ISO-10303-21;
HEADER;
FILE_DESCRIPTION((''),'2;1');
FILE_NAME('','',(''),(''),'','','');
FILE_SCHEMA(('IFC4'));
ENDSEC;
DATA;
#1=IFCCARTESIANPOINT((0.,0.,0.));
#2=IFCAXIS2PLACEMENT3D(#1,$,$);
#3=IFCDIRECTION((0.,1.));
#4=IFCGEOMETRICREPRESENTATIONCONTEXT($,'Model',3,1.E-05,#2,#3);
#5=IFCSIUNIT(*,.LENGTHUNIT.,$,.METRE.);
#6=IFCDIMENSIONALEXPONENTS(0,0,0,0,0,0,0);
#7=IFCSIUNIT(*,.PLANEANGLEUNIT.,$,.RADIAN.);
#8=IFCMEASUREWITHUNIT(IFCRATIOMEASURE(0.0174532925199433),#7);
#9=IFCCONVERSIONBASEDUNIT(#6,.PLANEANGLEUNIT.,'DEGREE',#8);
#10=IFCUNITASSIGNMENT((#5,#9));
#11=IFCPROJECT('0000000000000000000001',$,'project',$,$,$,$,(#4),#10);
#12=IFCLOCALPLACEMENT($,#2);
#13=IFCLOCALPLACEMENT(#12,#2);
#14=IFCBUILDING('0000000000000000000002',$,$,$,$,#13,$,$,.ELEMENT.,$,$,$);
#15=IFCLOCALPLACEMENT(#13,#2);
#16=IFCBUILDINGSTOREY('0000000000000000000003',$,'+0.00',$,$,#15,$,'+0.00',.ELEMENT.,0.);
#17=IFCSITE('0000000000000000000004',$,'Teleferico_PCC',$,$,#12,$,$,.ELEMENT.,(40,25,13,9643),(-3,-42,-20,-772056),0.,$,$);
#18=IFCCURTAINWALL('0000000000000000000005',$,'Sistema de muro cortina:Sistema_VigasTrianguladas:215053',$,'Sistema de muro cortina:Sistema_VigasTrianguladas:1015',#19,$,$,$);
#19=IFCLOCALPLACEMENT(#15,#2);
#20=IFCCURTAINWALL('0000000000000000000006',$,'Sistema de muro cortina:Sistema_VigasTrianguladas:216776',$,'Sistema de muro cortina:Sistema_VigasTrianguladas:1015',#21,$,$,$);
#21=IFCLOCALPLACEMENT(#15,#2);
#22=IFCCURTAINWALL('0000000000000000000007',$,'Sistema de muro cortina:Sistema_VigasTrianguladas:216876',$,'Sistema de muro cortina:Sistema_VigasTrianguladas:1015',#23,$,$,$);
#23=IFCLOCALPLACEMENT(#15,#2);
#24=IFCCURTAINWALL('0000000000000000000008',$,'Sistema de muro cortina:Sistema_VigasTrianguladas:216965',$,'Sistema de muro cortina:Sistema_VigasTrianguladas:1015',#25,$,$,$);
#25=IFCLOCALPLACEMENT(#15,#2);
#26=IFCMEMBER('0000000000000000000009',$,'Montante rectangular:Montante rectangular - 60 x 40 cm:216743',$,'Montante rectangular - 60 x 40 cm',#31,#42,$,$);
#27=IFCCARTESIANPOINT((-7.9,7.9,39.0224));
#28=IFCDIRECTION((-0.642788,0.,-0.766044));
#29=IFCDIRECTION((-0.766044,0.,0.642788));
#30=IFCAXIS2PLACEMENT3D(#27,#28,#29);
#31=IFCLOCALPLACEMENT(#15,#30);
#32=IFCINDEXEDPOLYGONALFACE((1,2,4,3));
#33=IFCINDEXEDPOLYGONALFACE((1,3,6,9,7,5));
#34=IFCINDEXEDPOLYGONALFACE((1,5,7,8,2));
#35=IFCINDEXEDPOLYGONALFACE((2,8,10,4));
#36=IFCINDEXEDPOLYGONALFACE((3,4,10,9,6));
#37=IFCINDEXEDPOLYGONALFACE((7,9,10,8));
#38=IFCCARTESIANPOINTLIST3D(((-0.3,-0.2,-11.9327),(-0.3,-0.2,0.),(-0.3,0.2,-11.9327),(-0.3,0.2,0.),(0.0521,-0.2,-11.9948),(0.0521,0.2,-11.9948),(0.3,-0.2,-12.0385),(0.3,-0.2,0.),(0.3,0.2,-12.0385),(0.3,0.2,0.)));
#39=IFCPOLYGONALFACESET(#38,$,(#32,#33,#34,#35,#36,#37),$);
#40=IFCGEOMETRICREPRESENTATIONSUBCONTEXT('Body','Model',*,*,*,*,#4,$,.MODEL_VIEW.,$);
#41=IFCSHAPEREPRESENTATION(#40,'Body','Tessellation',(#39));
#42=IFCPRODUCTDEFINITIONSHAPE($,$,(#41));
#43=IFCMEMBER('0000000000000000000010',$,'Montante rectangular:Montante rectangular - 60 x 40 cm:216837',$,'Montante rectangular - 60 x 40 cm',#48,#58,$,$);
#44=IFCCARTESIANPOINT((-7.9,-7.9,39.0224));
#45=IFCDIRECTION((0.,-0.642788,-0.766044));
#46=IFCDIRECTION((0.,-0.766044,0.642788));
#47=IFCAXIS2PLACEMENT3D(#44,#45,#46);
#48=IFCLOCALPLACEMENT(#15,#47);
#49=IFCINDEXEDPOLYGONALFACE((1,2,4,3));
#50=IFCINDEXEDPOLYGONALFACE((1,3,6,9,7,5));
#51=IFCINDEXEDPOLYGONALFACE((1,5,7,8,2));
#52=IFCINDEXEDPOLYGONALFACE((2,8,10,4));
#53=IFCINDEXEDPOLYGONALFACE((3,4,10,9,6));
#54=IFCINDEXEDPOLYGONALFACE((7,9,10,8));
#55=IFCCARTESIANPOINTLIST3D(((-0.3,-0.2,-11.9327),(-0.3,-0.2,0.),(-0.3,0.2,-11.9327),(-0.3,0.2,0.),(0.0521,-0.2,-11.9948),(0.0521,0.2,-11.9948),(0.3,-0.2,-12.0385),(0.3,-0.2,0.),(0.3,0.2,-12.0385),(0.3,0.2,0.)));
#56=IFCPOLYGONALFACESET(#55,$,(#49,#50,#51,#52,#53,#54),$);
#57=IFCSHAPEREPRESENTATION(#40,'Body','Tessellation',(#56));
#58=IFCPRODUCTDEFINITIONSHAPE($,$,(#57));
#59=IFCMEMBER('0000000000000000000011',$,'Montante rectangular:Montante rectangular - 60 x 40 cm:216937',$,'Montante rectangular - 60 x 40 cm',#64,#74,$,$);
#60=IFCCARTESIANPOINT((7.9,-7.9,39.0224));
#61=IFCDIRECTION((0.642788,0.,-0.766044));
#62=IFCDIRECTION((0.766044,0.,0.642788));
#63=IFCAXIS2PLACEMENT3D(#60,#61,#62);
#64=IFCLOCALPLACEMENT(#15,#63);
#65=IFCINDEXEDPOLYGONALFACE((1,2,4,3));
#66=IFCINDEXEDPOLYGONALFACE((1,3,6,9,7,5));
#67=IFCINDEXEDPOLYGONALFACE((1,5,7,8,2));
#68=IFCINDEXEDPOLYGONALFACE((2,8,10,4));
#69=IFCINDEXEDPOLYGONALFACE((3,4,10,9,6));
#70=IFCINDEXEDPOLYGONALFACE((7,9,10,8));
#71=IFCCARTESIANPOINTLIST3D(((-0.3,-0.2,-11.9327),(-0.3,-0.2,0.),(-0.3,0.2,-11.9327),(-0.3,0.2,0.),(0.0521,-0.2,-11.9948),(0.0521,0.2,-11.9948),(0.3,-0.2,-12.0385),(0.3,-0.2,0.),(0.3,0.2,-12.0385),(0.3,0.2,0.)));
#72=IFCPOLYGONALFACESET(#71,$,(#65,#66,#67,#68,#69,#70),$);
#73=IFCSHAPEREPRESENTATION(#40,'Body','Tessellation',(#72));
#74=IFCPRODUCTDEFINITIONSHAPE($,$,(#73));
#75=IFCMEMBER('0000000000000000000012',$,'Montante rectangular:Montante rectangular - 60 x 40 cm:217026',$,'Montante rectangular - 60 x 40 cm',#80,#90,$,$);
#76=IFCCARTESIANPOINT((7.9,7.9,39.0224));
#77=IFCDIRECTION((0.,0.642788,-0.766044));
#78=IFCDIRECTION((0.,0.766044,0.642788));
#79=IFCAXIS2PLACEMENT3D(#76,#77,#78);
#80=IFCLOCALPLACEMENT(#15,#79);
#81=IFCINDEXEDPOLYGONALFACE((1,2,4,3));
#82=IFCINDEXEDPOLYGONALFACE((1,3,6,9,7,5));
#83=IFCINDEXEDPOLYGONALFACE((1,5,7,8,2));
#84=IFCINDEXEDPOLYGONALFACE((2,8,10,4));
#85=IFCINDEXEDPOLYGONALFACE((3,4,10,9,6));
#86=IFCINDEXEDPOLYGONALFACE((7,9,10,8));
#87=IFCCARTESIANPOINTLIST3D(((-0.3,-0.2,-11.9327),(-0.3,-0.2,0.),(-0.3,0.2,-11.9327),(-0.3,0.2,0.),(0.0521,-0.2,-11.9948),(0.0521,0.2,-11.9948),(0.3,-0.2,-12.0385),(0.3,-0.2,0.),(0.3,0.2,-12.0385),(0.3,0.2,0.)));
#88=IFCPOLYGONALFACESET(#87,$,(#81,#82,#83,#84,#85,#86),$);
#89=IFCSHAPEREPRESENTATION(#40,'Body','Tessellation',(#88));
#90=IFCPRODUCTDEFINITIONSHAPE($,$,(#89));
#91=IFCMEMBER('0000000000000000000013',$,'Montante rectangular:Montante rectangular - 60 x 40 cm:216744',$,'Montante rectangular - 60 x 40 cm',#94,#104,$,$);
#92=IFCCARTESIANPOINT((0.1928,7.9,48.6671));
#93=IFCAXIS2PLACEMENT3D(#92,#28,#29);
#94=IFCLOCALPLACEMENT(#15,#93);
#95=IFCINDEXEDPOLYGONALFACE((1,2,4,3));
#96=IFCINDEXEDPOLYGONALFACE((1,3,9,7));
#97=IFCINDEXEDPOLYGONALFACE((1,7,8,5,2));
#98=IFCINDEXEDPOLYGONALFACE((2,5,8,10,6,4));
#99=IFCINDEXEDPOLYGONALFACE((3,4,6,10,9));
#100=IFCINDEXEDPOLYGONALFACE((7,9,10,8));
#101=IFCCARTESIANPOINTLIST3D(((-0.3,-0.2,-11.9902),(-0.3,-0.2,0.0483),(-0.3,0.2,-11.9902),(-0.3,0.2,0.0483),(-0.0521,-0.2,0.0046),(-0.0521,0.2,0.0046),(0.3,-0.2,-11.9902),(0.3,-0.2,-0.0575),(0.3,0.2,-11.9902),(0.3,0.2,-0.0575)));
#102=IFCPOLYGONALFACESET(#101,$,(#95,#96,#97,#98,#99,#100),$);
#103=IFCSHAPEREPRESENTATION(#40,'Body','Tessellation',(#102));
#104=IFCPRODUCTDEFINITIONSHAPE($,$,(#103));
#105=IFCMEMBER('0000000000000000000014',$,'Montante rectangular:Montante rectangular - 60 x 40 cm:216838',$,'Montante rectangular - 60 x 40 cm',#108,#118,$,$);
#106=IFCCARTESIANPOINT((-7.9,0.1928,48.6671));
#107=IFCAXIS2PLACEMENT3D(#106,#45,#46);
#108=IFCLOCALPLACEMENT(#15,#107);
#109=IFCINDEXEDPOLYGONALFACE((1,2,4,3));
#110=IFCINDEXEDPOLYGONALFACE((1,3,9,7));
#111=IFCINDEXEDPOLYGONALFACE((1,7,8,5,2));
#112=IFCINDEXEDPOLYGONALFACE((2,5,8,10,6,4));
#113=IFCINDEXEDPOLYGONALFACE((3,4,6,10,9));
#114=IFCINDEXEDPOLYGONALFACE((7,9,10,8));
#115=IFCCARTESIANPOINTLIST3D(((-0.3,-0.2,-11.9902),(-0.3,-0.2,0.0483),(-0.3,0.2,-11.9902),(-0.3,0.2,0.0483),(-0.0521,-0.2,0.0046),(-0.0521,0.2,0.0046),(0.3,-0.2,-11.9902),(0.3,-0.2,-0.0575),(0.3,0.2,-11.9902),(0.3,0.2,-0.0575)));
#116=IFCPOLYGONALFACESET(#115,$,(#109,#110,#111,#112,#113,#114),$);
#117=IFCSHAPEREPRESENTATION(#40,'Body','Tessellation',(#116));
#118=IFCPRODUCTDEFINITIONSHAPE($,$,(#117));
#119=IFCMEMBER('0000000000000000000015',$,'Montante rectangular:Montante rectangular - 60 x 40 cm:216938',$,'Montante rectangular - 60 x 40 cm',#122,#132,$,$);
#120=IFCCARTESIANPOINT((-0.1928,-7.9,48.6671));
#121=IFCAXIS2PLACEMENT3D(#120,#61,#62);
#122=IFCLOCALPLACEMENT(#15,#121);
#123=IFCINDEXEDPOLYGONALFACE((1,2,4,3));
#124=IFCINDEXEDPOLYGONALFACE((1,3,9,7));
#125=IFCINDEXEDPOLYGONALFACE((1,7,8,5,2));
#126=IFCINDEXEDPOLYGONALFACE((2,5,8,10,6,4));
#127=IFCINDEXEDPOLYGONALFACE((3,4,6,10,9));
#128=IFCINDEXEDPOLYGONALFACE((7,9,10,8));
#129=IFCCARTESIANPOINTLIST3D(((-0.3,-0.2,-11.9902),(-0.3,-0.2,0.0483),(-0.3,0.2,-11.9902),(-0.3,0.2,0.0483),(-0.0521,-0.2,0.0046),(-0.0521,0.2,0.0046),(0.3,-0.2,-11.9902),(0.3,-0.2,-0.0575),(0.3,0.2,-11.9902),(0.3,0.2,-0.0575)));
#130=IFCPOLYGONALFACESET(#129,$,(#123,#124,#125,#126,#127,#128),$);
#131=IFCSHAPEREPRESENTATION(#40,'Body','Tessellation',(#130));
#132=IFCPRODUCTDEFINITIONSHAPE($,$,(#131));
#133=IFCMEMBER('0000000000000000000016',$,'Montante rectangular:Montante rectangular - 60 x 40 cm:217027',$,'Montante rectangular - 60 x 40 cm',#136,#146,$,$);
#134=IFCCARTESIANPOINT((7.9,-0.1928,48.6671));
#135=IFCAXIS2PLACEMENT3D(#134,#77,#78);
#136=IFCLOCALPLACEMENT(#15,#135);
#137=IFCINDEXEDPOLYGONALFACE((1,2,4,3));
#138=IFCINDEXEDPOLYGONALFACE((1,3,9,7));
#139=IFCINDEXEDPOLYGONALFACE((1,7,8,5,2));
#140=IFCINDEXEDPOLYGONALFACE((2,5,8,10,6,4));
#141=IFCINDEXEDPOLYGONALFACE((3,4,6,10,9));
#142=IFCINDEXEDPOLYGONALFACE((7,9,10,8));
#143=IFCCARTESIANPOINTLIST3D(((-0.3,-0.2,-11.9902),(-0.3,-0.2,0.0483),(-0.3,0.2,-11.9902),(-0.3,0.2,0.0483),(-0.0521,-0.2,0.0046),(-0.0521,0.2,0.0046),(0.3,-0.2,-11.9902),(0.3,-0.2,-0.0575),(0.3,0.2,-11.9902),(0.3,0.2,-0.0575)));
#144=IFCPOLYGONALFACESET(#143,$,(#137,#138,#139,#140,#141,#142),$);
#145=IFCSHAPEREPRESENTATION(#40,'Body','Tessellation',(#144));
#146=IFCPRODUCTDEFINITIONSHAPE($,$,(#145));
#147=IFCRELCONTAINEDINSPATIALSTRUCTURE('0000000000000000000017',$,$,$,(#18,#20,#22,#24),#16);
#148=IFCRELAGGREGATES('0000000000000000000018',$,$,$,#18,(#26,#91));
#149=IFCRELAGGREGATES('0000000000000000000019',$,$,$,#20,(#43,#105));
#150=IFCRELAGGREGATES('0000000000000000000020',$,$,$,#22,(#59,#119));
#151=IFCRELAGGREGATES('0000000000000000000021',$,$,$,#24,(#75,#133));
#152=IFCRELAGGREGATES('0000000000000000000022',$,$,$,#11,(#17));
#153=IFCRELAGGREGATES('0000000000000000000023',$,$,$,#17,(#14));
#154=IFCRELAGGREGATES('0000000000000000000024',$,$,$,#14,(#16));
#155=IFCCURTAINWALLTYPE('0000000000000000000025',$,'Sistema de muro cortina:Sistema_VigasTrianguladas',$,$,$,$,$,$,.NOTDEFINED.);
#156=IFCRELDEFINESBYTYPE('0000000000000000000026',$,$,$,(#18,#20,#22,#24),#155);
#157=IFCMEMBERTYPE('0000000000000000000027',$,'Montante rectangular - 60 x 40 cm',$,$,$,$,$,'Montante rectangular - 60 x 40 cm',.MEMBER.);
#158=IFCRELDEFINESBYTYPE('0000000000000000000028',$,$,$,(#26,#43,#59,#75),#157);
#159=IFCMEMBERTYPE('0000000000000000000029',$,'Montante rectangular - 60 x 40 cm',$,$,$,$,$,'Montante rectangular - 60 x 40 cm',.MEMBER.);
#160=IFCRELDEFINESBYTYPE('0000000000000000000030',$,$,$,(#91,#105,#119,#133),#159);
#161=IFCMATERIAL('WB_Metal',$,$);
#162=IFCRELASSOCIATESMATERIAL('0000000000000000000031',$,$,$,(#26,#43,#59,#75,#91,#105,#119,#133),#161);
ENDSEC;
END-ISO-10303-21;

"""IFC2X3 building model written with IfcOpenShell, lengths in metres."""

from ifc_helpers import new_model, entity, si_unit, converted_unit, direction, frame, origin, origin_2d_with_axis, place, context, subcontext, project, spatial, polyline, rectangle, extrude, clip, bounded_halfspace, source, transform, mapped, material, type_object, type_shapes, element, aggregate, save


model = new_model("IFC2X3")

# Units and contexts
model_context = context("Model", 3, precision=1e-05, world=origin(), true_north=direction((0.0, 1.0)))
body_context = subcontext(model_context, "Body", "Model", "MODEL_VIEW")
ifc_project = project(units=[si_unit("LENGTHUNIT", "METRE"), converted_unit("PLANEANGLEUNIT", "DEGREE", entity("IfcRatioMeasure", 0.0174532925199433), si_unit("PLANEANGLEUNIT", "RADIAN"), dimensions=[0, 0, 0, 0, 0, 0, 0])], contexts=[model_context])

# Site, building, storey
site_placement = place(None, origin())
site = spatial("IfcSite", under=ifc_project, at=site_placement, Name="Teleferico_PCC", CompositionType="ELEMENT", RefLatitude=(40, 25, 13, 9643), RefLongitude=(-3, -42, -20, -772056), RefElevation=0.0)
building_placement = place(site_placement, origin())
building = spatial("IfcBuilding", under=site, at=building_placement, CompositionType="ELEMENT")
storey_placement = place(building_placement, origin())
storey = spatial("IfcBuildingStorey", under=building, at=storey_placement, Name="+0.00", LongName="+0.00", CompositionType="ELEMENT", Elevation=0.0)

# Curtain walls
curtain_wall_type = type_object("IfcCurtainWallType", Name="Sistema de muro cortina:Sistema_VigasTrianguladas", PredefinedType="NOTDEFINED")
curtain_wall_1_placement = place(storey_placement, origin())
curtain_wall_1 = element("IfcCurtainWall", 1, at=curtain_wall_1_placement, inside=storey, type_object=curtain_wall_type, Name="Sistema de muro cortina:Sistema_VigasTrianguladas:215053", ObjectType="Sistema de muro cortina:Sistema_VigasTrianguladas:1015")
ifc_material_1 = material(Name="WB_Metal")
curtain_wall_2_placement = place(storey_placement, origin())
curtain_wall_2 = element("IfcCurtainWall", 2, at=curtain_wall_2_placement, inside=storey, type_object=curtain_wall_type, Name="Sistema de muro cortina:Sistema_VigasTrianguladas:216776", ObjectType="Sistema de muro cortina:Sistema_VigasTrianguladas:1015")
curtain_wall_3_placement = place(storey_placement, origin())
curtain_wall_3 = element("IfcCurtainWall", 3, at=curtain_wall_3_placement, inside=storey, type_object=curtain_wall_type, Name="Sistema de muro cortina:Sistema_VigasTrianguladas:216876", ObjectType="Sistema de muro cortina:Sistema_VigasTrianguladas:1015")
curtain_wall_4_placement = place(storey_placement, origin())
curtain_wall_4 = element("IfcCurtainWall", 4, at=curtain_wall_4_placement, inside=storey, type_object=curtain_wall_type, Name="Sistema de muro cortina:Sistema_VigasTrianguladas:216965", ObjectType="Sistema de muro cortina:Sistema_VigasTrianguladas:1015")

# Members
member_type_1 = type_object("IfcMemberType", Name="Montante rectangular - 60 x 40 cm", ElementType="Montante rectangular - 60 x 40 cm", PredefinedType="MEMBER")
shared_shape_1 = source(origin(), body_context, "Body", "Clipping", [
    clip(clip(extrude(rectangle(XDim=0.4, YDim=0.6, at=origin_2d_with_axis()), frame((0.0, 0.0, -12.0385), z_axis=(0.0, 0.0, 1.0), x_axis=(0.0, -1.0, 0.0)), (0.0, 0.0, 1.0), 12.0385), bounded_halfspace(frame((12.1556, 91.44, -14.1289), z_axis=(-0.173648, 0.0, -0.984808), x_axis=(-0.984808, 0.0, 0.173648)), False, frame((0.0, 0.0, -12.0385), z_axis=(0.0, 0.0, 1.0), x_axis=(0.0, -1.0, 0.0)), polyline([(0.2, 0.3), (0.2, 0.0521), (-0.2, 0.0521), (-0.2, 0.3), (0.2, 0.3)]))), bounded_halfspace(frame((0.0521, 91.44, -11.9948), z_axis=(-0.173648, 0.0, -0.984808), x_axis=(-0.984808, 0.0, 0.173648)), False, frame((0.0, 0.0, -12.0385), z_axis=(0.0, 0.0, 1.0), x_axis=(0.0, -1.0, 0.0)), polyline([(0.2, 0.0521), (0.2, -0.3), (-0.2, -0.3), (-0.2, 0.0521), (0.2, 0.0521)]))),
])
type_shapes(member_type_1, [shared_shape_1])
member_1_placement = place(storey_placement, frame((-7.9, 7.9, 39.0224), z_axis=(-0.642788, 0.0, -0.766044), x_axis=(-0.766044, 0.0, 0.642788)))
member_1 = element("IfcMember", 5, at=member_1_placement, type_object=member_type_1, material=ifc_material_1, Name="Montante rectangular:Montante rectangular - 60 x 40 cm:216743", ObjectType="Montante rectangular - 60 x 40 cm", context=body_context, shape_type="MappedRepresentation", body=[
    mapped(shared_shape_1, transform((0.0, 0.0, 0.0), scale=1.0)),
])
member_2_placement = place(storey_placement, frame((-7.9, -7.9, 39.0224), z_axis=(0.0, -0.642788, -0.766044), x_axis=(0.0, -0.766044, 0.642788)))
member_2 = element("IfcMember", 6, at=member_2_placement, type_object=member_type_1, material=ifc_material_1, Name="Montante rectangular:Montante rectangular - 60 x 40 cm:216837", ObjectType="Montante rectangular - 60 x 40 cm", context=body_context, shape_type="MappedRepresentation", body=[
    mapped(shared_shape_1, transform((0.0, 0.0, 0.0), scale=1.0)),
])
member_3_placement = place(storey_placement, frame((7.9, -7.9, 39.0224), z_axis=(0.642788, 0.0, -0.766044), x_axis=(0.766044, 0.0, 0.642788)))
member_3 = element("IfcMember", 7, at=member_3_placement, type_object=member_type_1, material=ifc_material_1, Name="Montante rectangular:Montante rectangular - 60 x 40 cm:216937", ObjectType="Montante rectangular - 60 x 40 cm", context=body_context, shape_type="MappedRepresentation", body=[
    mapped(shared_shape_1, transform((0.0, 0.0, 0.0), scale=1.0)),
])
member_4_placement = place(storey_placement, frame((7.9, 7.9, 39.0224), z_axis=(0.0, 0.642788, -0.766044), x_axis=(0.0, 0.766044, 0.642788)))
member_4 = element("IfcMember", 8, at=member_4_placement, type_object=member_type_1, material=ifc_material_1, Name="Montante rectangular:Montante rectangular - 60 x 40 cm:217026", ObjectType="Montante rectangular - 60 x 40 cm", context=body_context, shape_type="MappedRepresentation", body=[
    mapped(shared_shape_1, transform((0.0, 0.0, 0.0), scale=1.0)),
])
member_type_2 = type_object("IfcMemberType", Name="Montante rectangular - 60 x 40 cm", ElementType="Montante rectangular - 60 x 40 cm", PredefinedType="MEMBER")
shared_shape_2 = source(origin(), body_context, "Body", "Clipping", [
    clip(clip(extrude(rectangle(XDim=0.4, YDim=0.6, at=origin_2d_with_axis()), frame((0.0, 0.0, -11.9902), z_axis=(0.0, 0.0, 1.0), x_axis=(0.0, -1.0, 0.0)), (0.0, 0.0, 1.0), 12.0385), bounded_halfspace(frame((12.0514, -91.44, -2.1296), z_axis=(0.173648, 0.0, 0.984808), x_axis=(-0.984808, 0.0, 0.173648)), False, frame((0.0, 0.0, -11.9902), z_axis=(0.0, 0.0, 1.0), x_axis=(0.0, -1.0, 0.0)), polyline([(0.2, 0.3), (-0.2, 0.3), (-0.2, -0.0521), (0.2, -0.0521), (0.2, 0.3)]))), bounded_halfspace(frame((-0.0521, -91.44, 0.0046), z_axis=(0.173648, 0.0, 0.984808), x_axis=(-0.984808, 0.0, 0.173648)), False, frame((0.0, 0.0, -11.9902), z_axis=(0.0, 0.0, 1.0), x_axis=(0.0, -1.0, 0.0)), polyline([(-0.2, -0.0521), (-0.2, -0.3), (0.2, -0.3), (0.2, -0.0521), (-0.2, -0.0521)]))),
])
type_shapes(member_type_2, [shared_shape_2])
member_5_placement = place(storey_placement, frame((0.1928, 7.9, 48.6671), z_axis=(-0.642788, 0.0, -0.766044), x_axis=(-0.766044, 0.0, 0.642788)))
member_5 = element("IfcMember", 9, at=member_5_placement, type_object=member_type_2, material=ifc_material_1, Name="Montante rectangular:Montante rectangular - 60 x 40 cm:216744", ObjectType="Montante rectangular - 60 x 40 cm", context=body_context, shape_type="MappedRepresentation", body=[
    mapped(shared_shape_2, transform((0.0, 0.0, 0.0), scale=1.0)),
])
aggregate(curtain_wall_1, [member_1, member_5])
member_6_placement = place(storey_placement, frame((-7.9, 0.1928, 48.6671), z_axis=(0.0, -0.642788, -0.766044), x_axis=(0.0, -0.766044, 0.642788)))
member_6 = element("IfcMember", 10, at=member_6_placement, type_object=member_type_2, material=ifc_material_1, Name="Montante rectangular:Montante rectangular - 60 x 40 cm:216838", ObjectType="Montante rectangular - 60 x 40 cm", context=body_context, shape_type="MappedRepresentation", body=[
    mapped(shared_shape_2, transform((0.0, 0.0, 0.0), scale=1.0)),
])
aggregate(curtain_wall_2, [member_2, member_6])
member_7_placement = place(storey_placement, frame((-0.1928, -7.9, 48.6671), z_axis=(0.642788, 0.0, -0.766044), x_axis=(0.766044, 0.0, 0.642788)))
member_7 = element("IfcMember", 11, at=member_7_placement, type_object=member_type_2, material=ifc_material_1, Name="Montante rectangular:Montante rectangular - 60 x 40 cm:216938", ObjectType="Montante rectangular - 60 x 40 cm", context=body_context, shape_type="MappedRepresentation", body=[
    mapped(shared_shape_2, transform((0.0, 0.0, 0.0), scale=1.0)),
])
aggregate(curtain_wall_3, [member_3, member_7])
member_8_placement = place(storey_placement, frame((7.9, -0.1928, 48.6671), z_axis=(0.0, 0.642788, -0.766044), x_axis=(0.0, 0.766044, 0.642788)))
member_8 = element("IfcMember", 12, at=member_8_placement, type_object=member_type_2, material=ifc_material_1, Name="Montante rectangular:Montante rectangular - 60 x 40 cm:217027", ObjectType="Montante rectangular - 60 x 40 cm", context=body_context, shape_type="MappedRepresentation", body=[
    mapped(shared_shape_2, transform((0.0, 0.0, 0.0), scale=1.0)),
])
aggregate(curtain_wall_4, [member_4, member_8])

save(model, "model.ifc")
